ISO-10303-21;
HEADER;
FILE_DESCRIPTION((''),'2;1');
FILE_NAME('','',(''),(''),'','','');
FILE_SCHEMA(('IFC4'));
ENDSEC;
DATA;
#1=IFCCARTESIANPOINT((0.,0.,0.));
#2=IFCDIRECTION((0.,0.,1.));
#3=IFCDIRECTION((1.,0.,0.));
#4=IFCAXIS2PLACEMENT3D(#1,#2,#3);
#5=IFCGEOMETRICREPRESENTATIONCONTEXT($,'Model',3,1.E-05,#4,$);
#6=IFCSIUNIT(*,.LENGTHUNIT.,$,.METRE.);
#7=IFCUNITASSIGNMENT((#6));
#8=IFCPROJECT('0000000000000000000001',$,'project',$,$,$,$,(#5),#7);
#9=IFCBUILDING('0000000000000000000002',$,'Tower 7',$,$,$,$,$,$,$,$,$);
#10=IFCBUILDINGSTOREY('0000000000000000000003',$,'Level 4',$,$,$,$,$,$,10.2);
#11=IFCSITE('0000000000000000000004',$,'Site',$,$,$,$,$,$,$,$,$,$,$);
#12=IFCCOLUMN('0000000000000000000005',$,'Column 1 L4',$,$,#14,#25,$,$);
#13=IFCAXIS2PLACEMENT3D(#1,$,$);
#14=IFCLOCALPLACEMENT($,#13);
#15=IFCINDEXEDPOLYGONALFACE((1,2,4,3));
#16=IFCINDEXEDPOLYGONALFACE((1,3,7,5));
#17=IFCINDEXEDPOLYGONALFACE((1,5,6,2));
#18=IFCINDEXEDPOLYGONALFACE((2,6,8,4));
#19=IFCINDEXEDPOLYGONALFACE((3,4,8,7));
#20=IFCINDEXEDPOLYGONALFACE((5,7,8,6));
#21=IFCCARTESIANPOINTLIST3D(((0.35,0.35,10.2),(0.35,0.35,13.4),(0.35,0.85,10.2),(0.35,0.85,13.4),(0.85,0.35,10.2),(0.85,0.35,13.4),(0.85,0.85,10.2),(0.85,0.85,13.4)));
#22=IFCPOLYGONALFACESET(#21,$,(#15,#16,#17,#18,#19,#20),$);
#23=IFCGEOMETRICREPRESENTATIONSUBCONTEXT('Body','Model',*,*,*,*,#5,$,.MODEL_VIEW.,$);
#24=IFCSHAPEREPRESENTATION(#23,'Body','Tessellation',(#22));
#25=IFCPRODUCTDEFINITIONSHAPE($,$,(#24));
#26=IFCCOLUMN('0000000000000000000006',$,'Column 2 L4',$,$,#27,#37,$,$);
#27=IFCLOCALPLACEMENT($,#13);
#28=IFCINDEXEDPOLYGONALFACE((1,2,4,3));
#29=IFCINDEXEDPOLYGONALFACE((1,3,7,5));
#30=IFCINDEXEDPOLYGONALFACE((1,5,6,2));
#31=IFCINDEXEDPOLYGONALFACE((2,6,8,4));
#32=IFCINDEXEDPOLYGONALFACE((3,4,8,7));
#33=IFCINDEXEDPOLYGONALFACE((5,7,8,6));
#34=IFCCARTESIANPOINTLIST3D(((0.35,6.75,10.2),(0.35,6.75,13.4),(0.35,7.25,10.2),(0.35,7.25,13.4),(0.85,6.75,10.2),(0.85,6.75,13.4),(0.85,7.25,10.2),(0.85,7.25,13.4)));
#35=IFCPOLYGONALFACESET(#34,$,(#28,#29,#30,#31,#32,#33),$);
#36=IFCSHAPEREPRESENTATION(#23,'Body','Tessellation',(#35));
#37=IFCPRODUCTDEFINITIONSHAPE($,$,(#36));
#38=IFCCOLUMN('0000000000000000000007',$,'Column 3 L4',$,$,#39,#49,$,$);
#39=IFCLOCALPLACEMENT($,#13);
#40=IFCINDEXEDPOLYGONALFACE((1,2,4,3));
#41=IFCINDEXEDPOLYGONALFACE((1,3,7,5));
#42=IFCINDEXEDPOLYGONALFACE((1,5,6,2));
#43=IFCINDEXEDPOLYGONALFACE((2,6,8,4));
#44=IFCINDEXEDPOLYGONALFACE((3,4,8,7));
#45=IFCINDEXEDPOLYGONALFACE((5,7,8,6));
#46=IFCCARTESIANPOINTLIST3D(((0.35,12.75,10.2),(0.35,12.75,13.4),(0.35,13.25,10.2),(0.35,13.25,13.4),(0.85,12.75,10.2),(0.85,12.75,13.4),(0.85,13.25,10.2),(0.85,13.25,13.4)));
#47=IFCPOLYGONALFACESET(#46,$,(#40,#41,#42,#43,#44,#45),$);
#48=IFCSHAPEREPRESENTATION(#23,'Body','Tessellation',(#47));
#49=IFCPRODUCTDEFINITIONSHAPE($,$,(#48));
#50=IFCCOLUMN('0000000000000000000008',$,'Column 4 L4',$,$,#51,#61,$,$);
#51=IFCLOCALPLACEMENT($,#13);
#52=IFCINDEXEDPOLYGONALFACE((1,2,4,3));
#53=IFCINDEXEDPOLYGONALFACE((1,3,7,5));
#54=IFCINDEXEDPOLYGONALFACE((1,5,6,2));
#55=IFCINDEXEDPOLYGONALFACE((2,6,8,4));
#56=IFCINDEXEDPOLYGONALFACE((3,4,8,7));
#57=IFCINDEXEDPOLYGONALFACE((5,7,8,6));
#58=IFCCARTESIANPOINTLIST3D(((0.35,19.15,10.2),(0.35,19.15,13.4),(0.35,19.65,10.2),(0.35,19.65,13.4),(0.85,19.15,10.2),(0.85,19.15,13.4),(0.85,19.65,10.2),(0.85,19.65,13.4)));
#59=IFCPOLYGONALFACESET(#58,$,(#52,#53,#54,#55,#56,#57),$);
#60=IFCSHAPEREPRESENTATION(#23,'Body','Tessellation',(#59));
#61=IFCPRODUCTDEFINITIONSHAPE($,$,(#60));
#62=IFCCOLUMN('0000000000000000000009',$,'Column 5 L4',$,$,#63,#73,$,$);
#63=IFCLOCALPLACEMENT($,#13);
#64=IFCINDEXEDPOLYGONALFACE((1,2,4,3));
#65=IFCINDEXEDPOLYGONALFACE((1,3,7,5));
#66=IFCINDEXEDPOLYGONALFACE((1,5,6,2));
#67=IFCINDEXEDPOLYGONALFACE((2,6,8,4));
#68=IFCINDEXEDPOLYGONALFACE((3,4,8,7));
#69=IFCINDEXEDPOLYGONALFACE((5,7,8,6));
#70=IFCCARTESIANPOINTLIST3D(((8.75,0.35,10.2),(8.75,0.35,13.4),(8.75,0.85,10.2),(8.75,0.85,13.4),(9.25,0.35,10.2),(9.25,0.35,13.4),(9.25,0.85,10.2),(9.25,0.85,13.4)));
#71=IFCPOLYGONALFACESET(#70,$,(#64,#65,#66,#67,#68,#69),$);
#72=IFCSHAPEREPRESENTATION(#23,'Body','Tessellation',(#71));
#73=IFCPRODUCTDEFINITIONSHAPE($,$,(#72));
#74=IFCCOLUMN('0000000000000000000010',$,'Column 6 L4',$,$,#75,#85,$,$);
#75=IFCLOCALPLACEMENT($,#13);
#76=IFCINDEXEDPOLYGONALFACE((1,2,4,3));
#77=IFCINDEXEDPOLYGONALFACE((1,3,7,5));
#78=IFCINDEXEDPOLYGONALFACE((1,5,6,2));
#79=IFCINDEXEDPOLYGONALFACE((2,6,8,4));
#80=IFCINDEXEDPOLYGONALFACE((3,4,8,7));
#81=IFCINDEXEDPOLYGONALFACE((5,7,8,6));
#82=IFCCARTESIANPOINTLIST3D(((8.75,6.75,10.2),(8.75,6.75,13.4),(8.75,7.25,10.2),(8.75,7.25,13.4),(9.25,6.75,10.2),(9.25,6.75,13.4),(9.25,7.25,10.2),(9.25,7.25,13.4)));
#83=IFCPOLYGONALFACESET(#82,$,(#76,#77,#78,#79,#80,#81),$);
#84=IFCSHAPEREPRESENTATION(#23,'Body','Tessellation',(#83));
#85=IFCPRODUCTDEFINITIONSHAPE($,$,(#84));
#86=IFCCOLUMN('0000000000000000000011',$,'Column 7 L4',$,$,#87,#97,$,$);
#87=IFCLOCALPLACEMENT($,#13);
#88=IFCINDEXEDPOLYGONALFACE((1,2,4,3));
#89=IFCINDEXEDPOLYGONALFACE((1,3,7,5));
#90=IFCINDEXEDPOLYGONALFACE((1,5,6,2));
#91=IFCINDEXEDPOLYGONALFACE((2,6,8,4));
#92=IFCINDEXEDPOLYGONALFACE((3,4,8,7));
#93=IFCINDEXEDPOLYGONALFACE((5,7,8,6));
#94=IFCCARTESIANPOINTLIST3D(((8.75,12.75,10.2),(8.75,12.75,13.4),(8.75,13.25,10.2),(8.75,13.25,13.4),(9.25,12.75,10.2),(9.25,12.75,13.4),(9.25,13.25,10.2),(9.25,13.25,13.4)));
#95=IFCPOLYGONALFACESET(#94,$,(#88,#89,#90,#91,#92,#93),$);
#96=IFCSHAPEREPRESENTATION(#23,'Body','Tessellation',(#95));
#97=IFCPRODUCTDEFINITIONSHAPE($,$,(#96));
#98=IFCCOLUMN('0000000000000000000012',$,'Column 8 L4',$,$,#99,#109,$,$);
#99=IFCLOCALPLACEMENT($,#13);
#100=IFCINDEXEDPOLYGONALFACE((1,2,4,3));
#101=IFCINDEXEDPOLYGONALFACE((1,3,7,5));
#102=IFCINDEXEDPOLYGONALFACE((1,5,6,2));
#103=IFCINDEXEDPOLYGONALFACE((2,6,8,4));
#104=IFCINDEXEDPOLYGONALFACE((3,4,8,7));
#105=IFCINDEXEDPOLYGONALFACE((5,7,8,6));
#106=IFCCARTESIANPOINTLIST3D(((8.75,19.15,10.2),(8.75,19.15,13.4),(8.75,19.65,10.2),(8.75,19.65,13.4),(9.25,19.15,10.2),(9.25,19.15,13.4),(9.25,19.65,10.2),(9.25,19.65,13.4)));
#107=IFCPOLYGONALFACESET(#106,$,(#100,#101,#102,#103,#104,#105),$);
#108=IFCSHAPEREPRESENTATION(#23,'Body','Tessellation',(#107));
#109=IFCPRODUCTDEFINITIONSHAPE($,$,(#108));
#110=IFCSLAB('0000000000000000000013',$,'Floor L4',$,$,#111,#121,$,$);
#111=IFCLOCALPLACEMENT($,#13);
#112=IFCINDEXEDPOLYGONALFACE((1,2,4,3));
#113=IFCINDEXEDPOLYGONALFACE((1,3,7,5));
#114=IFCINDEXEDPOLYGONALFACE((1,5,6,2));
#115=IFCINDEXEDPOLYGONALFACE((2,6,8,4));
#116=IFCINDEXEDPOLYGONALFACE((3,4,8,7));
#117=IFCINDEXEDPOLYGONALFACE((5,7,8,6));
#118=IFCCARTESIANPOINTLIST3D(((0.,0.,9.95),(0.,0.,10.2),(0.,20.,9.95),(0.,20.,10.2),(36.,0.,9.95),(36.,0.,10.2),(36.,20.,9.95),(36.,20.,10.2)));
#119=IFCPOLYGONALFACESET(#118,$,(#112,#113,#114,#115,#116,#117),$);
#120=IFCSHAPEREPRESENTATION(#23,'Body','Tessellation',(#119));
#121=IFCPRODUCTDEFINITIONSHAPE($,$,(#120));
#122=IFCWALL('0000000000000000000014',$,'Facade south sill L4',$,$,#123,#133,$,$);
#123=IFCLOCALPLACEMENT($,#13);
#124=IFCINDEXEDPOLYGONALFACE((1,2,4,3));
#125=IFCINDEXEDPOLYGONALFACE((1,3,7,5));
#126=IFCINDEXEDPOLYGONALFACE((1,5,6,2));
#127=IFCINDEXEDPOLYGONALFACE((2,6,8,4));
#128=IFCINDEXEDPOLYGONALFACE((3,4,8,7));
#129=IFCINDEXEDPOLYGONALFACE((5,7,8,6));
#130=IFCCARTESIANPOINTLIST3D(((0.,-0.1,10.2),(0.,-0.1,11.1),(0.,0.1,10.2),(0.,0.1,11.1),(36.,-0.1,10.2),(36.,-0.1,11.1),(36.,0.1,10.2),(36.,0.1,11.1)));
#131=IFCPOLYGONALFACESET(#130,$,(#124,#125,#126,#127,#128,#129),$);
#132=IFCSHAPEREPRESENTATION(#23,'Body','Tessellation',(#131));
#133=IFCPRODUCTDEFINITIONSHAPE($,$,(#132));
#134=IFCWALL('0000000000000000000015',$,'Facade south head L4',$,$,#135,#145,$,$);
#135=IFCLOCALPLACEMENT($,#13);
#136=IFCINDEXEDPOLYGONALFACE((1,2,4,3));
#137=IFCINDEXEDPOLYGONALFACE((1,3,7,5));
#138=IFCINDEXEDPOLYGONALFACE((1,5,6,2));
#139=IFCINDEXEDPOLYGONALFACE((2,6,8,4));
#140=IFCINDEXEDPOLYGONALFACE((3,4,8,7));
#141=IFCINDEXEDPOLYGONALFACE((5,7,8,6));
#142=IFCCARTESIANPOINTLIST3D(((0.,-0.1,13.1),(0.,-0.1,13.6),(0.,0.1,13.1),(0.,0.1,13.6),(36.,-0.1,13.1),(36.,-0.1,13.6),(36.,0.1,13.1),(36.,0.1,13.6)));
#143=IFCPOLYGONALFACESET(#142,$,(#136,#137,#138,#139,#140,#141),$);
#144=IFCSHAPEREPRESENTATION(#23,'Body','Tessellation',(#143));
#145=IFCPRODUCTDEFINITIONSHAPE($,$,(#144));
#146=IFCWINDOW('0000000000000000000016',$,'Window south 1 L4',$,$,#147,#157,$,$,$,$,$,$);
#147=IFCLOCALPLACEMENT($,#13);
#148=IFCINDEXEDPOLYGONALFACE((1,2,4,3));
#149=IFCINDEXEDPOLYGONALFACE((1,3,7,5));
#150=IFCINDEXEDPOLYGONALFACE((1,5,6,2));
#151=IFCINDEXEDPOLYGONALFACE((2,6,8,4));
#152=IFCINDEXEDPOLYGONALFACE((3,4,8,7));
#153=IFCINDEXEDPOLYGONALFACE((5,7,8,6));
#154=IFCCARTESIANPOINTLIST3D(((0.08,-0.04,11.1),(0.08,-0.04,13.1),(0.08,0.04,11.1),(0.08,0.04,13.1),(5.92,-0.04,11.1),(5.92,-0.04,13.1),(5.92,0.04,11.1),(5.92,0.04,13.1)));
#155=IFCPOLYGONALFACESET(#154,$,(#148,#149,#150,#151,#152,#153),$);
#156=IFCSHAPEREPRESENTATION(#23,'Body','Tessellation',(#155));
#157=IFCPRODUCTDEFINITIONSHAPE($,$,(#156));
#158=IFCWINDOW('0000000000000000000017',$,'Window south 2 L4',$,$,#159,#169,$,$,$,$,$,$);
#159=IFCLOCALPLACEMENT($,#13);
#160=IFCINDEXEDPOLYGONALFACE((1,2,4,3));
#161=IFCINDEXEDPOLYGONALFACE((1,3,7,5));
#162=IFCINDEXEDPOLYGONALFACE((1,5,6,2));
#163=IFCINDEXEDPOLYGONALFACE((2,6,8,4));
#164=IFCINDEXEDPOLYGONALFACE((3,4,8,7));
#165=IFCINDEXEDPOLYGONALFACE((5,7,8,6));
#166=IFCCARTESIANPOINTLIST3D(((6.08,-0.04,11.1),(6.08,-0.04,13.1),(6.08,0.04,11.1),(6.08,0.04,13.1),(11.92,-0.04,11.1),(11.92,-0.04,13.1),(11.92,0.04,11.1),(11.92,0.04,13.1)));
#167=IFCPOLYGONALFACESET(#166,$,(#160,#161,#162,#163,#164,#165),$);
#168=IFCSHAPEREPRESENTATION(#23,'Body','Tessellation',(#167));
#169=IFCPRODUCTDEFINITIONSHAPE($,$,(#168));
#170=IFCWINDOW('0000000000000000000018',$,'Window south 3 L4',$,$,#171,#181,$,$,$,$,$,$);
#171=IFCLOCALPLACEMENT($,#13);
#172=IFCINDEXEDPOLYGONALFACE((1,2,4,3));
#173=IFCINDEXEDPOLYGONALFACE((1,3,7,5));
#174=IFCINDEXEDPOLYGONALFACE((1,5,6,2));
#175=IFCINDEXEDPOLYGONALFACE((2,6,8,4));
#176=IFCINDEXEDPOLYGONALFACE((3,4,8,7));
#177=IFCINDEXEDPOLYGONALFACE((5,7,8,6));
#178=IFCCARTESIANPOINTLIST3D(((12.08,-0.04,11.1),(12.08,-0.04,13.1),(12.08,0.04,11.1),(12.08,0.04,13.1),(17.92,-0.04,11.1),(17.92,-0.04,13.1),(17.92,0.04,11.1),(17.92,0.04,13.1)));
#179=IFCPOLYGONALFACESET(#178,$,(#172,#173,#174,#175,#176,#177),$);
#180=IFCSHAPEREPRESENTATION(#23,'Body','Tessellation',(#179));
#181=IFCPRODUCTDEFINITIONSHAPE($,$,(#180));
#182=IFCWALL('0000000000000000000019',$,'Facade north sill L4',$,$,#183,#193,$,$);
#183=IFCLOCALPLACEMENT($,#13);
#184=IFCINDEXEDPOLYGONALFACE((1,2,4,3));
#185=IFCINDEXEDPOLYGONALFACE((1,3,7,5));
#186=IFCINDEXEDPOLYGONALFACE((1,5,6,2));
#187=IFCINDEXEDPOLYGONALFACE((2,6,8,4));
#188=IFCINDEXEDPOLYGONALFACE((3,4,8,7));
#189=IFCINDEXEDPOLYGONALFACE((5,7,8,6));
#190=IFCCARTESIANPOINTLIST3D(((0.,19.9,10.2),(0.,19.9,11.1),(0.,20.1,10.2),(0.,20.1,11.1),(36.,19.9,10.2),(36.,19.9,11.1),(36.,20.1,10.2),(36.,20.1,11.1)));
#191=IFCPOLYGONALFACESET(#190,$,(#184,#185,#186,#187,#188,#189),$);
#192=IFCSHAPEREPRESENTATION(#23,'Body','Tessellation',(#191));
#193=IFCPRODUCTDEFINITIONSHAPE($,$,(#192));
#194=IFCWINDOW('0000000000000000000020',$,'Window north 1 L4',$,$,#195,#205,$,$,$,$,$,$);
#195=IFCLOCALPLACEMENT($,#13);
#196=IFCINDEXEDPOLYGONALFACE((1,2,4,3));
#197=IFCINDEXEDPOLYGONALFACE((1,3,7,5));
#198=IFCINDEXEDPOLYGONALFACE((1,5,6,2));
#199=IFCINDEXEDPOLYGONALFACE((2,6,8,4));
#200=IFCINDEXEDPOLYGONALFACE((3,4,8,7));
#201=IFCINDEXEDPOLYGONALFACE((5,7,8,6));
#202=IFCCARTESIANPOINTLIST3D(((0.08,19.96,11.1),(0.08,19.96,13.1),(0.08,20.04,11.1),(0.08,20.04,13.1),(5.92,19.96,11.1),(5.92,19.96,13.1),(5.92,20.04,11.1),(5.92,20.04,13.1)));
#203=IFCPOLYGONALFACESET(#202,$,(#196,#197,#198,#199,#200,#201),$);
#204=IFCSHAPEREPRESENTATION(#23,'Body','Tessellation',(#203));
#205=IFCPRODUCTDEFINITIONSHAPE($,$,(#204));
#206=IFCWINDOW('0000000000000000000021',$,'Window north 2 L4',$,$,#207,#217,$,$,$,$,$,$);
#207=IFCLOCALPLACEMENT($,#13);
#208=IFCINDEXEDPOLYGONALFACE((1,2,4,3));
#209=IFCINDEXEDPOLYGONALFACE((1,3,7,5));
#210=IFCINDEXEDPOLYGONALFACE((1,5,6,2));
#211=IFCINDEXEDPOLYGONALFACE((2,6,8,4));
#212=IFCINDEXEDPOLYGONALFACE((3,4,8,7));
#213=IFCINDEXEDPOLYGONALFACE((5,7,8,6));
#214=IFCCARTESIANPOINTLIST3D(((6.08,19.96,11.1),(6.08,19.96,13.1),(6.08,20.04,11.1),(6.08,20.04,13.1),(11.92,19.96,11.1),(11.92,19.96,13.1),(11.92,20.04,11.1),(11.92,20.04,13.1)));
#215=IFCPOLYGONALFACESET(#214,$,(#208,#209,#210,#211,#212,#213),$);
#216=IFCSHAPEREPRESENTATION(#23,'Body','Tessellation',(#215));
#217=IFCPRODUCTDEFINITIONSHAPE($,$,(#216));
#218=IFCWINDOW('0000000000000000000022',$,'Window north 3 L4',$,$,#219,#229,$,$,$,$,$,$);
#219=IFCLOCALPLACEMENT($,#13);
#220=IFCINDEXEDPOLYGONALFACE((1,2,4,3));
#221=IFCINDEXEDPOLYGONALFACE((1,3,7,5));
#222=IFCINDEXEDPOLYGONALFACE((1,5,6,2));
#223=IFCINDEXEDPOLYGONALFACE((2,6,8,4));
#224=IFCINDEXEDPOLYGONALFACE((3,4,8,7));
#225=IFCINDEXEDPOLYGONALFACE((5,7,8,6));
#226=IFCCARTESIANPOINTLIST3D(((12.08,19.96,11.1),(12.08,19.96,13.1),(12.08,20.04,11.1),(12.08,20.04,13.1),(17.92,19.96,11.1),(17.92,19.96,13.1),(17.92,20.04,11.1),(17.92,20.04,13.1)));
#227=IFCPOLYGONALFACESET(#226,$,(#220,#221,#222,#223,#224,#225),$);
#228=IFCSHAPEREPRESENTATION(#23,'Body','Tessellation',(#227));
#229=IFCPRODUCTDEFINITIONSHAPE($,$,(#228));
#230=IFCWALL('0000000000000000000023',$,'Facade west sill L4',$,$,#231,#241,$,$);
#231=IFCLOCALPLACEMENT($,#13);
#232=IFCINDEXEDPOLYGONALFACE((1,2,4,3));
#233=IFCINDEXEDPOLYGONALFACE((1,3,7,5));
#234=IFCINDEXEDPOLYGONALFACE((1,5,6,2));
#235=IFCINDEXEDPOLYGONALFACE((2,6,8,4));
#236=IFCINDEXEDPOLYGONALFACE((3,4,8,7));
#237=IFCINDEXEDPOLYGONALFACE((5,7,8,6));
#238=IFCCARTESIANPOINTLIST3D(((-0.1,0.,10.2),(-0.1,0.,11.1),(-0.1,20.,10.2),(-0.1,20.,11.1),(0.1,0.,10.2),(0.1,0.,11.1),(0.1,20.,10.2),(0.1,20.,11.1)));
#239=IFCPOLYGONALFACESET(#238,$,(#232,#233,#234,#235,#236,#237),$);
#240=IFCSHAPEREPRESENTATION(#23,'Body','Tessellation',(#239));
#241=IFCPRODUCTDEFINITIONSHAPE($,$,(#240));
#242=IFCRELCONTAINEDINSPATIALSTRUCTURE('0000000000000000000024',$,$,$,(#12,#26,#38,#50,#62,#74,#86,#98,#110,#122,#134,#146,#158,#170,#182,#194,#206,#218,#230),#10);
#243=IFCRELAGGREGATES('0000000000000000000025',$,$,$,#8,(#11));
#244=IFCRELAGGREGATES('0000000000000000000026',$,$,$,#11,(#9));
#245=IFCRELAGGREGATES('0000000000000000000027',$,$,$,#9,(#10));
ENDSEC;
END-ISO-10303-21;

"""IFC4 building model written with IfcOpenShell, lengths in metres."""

from ifc_helpers import new_model, si_unit, frame, origin, origin_with_axes, origin_2d, place, context, subcontext, project, spatial, rectangle, extrude, element, save


model = new_model("IFC4")

# Units and contexts
model_context = context("Model", 3, precision=1e-05, world=origin_with_axes())
body_context = subcontext(model_context, "Body", "Model", "MODEL_VIEW")
ifc_project = project(units=[si_unit("LENGTHUNIT", "METRE")], contexts=[model_context])

# Site, building, storey
site = spatial("IfcSite", under=ifc_project, Name="Site")
building = spatial("IfcBuilding", under=site, Name="Tower 7")
storey = spatial("IfcBuildingStorey", under=building, Name="Level 4", Elevation=10.2)

# Columns
for number, where, z_axis, x_axis, name in (
    (1, (0.6, 0.6, 10.2), (0.0, 0.0, 1.0), (1.0, 0.0, 0.0), "Column 1 L4"),
    (2, (0.6, 7.0, 10.2), (0.0, 0.0, 1.0), (1.0, 0.0, 0.0), "Column 2 L4"),
    (3, (0.6, 13.0, 10.2), (0.0, 0.0, 1.0), (1.0, 0.0, 0.0), "Column 3 L4"),
    (4, (0.6, 19.4, 10.2), (0.0, 0.0, 1.0), (1.0, 0.0, 0.0), "Column 4 L4"),
    (5, (9.0, 0.6, 10.2), (0.0, 0.0, 1.0), (1.0, 0.0, 0.0), "Column 5 L4"),
    (6, (9.0, 7.0, 10.2), (0.0, 0.0, 1.0), (1.0, 0.0, 0.0), "Column 6 L4"),
    (7, (9.0, 13.0, 10.2), (0.0, 0.0, 1.0), (1.0, 0.0, 0.0), "Column 7 L4"),
    (8, (9.0, 19.4, 10.2), (0.0, 0.0, 1.0), (1.0, 0.0, 0.0), "Column 8 L4"),
):
    element("IfcColumn", number, at=place(None, frame(where, z_axis=z_axis, x_axis=x_axis)), inside=storey, Name=name, context=body_context, shape_type="SweptSolid", body=[
        extrude(rectangle(XDim=0.5, YDim=0.5, at=origin_2d()), origin(), (0.0, 0.0, 1.0), 3.2),
    ])

# Slab
slab_placement = place(None, frame((18.0, 10.0, 9.95), z_axis=(0.0, 0.0, 1.0), x_axis=(1.0, 0.0, 0.0)))
element("IfcSlab", 9, at=slab_placement, inside=storey, Name="Floor L4", context=body_context, shape_type="SweptSolid", body=[
    extrude(rectangle(XDim=36.0, YDim=20.0, at=origin_2d()), origin(), (0.0, 0.0, 1.0), 0.25),
])

# Walls
wall_1_placement = place(None, frame((18.0, 0.0, 10.2), z_axis=(0.0, 0.0, 1.0), x_axis=(1.0, 0.0, 0.0)))
element("IfcWall", 10, at=wall_1_placement, inside=storey, Name="Facade south sill L4", context=body_context, shape_type="SweptSolid", body=[
    extrude(rectangle(XDim=36.0, YDim=0.2, at=origin_2d()), origin(), (0.0, 0.0, 1.0), 0.9),
])
wall_2_placement = place(None, frame((18.0, 0.0, 13.1), z_axis=(0.0, 0.0, 1.0), x_axis=(1.0, 0.0, 0.0)))
element("IfcWall", 11, at=wall_2_placement, inside=storey, Name="Facade south head L4", context=body_context, shape_type="SweptSolid", body=[
    extrude(rectangle(XDim=36.0, YDim=0.2, at=origin_2d()), origin(), (0.0, 0.0, 1.0), 0.5),
])

# Windows
for number, where, z_axis, x_axis, name in (
    (12, (3.0, 0.0, 11.1), (0.0, 0.0, 1.0), (1.0, 0.0, 0.0), "Window south 1 L4"),
    (13, (9.0, 0.0, 11.1), (0.0, 0.0, 1.0), (1.0, 0.0, 0.0), "Window south 2 L4"),
):
    element("IfcWindow", number, at=place(None, frame(where, z_axis=z_axis, x_axis=x_axis)), inside=storey, Name=name, context=body_context, shape_type="SweptSolid", body=[
        extrude(rectangle(XDim=5.84, YDim=0.08, at=origin_2d()), origin(), (0.0, 0.0, 1.0), 2.0),
    ])
window_1_placement = place(None, frame((15.0, 0.0, 11.1), z_axis=(0.0, 0.0, 1.0), x_axis=(1.0, 0.0, 0.0)))
element("IfcWindow", 14, at=window_1_placement, inside=storey, Name="Window south 3 L4", context=body_context, shape_type="SweptSolid", body=[
    extrude(rectangle(XDim=5.84, YDim=0.08, at=origin_2d()), origin(), (0.0, 0.0, 1.0), 2.0),
])

# Wall
wall_3_placement = place(None, frame((18.0, 20.0, 10.2), z_axis=(0.0, 0.0, 1.0), x_axis=(1.0, 0.0, 0.0)))
element("IfcWall", 15, at=wall_3_placement, inside=storey, Name="Facade north sill L4", context=body_context, shape_type="SweptSolid", body=[
    extrude(rectangle(XDim=36.0, YDim=0.2, at=origin_2d()), origin(), (0.0, 0.0, 1.0), 0.9),
])

# Windows
for number, where, z_axis, x_axis, name in (
    (16, (3.0, 20.0, 11.1), (0.0, 0.0, 1.0), (1.0, 0.0, 0.0), "Window north 1 L4"),
    (17, (9.0, 20.0, 11.1), (0.0, 0.0, 1.0), (1.0, 0.0, 0.0), "Window north 2 L4"),
):
    element("IfcWindow", number, at=place(None, frame(where, z_axis=z_axis, x_axis=x_axis)), inside=storey, Name=name, context=body_context, shape_type="SweptSolid", body=[
        extrude(rectangle(XDim=5.84, YDim=0.08, at=origin_2d()), origin(), (0.0, 0.0, 1.0), 2.0),
    ])
window_2_placement = place(None, frame((15.0, 20.0, 11.1), z_axis=(0.0, 0.0, 1.0), x_axis=(1.0, 0.0, 0.0)))
element("IfcWindow", 18, at=window_2_placement, inside=storey, Name="Window north 3 L4", context=body_context, shape_type="SweptSolid", body=[
    extrude(rectangle(XDim=5.84, YDim=0.08, at=origin_2d()), origin(), (0.0, 0.0, 1.0), 2.0),
])

# Wall
wall_4_placement = place(None, frame((0.0, 10.0, 10.2), z_axis=(0.0, 0.0, 1.0), x_axis=(1.0, 0.0, 0.0)))
element("IfcWall", 19, at=wall_4_placement, inside=storey, Name="Facade west sill L4", context=body_context, shape_type="SweptSolid", body=[
    extrude(rectangle(XDim=0.2, YDim=20.0, at=origin_2d()), origin(), (0.0, 0.0, 1.0), 0.9),
])

save(model, "model.ifc")
